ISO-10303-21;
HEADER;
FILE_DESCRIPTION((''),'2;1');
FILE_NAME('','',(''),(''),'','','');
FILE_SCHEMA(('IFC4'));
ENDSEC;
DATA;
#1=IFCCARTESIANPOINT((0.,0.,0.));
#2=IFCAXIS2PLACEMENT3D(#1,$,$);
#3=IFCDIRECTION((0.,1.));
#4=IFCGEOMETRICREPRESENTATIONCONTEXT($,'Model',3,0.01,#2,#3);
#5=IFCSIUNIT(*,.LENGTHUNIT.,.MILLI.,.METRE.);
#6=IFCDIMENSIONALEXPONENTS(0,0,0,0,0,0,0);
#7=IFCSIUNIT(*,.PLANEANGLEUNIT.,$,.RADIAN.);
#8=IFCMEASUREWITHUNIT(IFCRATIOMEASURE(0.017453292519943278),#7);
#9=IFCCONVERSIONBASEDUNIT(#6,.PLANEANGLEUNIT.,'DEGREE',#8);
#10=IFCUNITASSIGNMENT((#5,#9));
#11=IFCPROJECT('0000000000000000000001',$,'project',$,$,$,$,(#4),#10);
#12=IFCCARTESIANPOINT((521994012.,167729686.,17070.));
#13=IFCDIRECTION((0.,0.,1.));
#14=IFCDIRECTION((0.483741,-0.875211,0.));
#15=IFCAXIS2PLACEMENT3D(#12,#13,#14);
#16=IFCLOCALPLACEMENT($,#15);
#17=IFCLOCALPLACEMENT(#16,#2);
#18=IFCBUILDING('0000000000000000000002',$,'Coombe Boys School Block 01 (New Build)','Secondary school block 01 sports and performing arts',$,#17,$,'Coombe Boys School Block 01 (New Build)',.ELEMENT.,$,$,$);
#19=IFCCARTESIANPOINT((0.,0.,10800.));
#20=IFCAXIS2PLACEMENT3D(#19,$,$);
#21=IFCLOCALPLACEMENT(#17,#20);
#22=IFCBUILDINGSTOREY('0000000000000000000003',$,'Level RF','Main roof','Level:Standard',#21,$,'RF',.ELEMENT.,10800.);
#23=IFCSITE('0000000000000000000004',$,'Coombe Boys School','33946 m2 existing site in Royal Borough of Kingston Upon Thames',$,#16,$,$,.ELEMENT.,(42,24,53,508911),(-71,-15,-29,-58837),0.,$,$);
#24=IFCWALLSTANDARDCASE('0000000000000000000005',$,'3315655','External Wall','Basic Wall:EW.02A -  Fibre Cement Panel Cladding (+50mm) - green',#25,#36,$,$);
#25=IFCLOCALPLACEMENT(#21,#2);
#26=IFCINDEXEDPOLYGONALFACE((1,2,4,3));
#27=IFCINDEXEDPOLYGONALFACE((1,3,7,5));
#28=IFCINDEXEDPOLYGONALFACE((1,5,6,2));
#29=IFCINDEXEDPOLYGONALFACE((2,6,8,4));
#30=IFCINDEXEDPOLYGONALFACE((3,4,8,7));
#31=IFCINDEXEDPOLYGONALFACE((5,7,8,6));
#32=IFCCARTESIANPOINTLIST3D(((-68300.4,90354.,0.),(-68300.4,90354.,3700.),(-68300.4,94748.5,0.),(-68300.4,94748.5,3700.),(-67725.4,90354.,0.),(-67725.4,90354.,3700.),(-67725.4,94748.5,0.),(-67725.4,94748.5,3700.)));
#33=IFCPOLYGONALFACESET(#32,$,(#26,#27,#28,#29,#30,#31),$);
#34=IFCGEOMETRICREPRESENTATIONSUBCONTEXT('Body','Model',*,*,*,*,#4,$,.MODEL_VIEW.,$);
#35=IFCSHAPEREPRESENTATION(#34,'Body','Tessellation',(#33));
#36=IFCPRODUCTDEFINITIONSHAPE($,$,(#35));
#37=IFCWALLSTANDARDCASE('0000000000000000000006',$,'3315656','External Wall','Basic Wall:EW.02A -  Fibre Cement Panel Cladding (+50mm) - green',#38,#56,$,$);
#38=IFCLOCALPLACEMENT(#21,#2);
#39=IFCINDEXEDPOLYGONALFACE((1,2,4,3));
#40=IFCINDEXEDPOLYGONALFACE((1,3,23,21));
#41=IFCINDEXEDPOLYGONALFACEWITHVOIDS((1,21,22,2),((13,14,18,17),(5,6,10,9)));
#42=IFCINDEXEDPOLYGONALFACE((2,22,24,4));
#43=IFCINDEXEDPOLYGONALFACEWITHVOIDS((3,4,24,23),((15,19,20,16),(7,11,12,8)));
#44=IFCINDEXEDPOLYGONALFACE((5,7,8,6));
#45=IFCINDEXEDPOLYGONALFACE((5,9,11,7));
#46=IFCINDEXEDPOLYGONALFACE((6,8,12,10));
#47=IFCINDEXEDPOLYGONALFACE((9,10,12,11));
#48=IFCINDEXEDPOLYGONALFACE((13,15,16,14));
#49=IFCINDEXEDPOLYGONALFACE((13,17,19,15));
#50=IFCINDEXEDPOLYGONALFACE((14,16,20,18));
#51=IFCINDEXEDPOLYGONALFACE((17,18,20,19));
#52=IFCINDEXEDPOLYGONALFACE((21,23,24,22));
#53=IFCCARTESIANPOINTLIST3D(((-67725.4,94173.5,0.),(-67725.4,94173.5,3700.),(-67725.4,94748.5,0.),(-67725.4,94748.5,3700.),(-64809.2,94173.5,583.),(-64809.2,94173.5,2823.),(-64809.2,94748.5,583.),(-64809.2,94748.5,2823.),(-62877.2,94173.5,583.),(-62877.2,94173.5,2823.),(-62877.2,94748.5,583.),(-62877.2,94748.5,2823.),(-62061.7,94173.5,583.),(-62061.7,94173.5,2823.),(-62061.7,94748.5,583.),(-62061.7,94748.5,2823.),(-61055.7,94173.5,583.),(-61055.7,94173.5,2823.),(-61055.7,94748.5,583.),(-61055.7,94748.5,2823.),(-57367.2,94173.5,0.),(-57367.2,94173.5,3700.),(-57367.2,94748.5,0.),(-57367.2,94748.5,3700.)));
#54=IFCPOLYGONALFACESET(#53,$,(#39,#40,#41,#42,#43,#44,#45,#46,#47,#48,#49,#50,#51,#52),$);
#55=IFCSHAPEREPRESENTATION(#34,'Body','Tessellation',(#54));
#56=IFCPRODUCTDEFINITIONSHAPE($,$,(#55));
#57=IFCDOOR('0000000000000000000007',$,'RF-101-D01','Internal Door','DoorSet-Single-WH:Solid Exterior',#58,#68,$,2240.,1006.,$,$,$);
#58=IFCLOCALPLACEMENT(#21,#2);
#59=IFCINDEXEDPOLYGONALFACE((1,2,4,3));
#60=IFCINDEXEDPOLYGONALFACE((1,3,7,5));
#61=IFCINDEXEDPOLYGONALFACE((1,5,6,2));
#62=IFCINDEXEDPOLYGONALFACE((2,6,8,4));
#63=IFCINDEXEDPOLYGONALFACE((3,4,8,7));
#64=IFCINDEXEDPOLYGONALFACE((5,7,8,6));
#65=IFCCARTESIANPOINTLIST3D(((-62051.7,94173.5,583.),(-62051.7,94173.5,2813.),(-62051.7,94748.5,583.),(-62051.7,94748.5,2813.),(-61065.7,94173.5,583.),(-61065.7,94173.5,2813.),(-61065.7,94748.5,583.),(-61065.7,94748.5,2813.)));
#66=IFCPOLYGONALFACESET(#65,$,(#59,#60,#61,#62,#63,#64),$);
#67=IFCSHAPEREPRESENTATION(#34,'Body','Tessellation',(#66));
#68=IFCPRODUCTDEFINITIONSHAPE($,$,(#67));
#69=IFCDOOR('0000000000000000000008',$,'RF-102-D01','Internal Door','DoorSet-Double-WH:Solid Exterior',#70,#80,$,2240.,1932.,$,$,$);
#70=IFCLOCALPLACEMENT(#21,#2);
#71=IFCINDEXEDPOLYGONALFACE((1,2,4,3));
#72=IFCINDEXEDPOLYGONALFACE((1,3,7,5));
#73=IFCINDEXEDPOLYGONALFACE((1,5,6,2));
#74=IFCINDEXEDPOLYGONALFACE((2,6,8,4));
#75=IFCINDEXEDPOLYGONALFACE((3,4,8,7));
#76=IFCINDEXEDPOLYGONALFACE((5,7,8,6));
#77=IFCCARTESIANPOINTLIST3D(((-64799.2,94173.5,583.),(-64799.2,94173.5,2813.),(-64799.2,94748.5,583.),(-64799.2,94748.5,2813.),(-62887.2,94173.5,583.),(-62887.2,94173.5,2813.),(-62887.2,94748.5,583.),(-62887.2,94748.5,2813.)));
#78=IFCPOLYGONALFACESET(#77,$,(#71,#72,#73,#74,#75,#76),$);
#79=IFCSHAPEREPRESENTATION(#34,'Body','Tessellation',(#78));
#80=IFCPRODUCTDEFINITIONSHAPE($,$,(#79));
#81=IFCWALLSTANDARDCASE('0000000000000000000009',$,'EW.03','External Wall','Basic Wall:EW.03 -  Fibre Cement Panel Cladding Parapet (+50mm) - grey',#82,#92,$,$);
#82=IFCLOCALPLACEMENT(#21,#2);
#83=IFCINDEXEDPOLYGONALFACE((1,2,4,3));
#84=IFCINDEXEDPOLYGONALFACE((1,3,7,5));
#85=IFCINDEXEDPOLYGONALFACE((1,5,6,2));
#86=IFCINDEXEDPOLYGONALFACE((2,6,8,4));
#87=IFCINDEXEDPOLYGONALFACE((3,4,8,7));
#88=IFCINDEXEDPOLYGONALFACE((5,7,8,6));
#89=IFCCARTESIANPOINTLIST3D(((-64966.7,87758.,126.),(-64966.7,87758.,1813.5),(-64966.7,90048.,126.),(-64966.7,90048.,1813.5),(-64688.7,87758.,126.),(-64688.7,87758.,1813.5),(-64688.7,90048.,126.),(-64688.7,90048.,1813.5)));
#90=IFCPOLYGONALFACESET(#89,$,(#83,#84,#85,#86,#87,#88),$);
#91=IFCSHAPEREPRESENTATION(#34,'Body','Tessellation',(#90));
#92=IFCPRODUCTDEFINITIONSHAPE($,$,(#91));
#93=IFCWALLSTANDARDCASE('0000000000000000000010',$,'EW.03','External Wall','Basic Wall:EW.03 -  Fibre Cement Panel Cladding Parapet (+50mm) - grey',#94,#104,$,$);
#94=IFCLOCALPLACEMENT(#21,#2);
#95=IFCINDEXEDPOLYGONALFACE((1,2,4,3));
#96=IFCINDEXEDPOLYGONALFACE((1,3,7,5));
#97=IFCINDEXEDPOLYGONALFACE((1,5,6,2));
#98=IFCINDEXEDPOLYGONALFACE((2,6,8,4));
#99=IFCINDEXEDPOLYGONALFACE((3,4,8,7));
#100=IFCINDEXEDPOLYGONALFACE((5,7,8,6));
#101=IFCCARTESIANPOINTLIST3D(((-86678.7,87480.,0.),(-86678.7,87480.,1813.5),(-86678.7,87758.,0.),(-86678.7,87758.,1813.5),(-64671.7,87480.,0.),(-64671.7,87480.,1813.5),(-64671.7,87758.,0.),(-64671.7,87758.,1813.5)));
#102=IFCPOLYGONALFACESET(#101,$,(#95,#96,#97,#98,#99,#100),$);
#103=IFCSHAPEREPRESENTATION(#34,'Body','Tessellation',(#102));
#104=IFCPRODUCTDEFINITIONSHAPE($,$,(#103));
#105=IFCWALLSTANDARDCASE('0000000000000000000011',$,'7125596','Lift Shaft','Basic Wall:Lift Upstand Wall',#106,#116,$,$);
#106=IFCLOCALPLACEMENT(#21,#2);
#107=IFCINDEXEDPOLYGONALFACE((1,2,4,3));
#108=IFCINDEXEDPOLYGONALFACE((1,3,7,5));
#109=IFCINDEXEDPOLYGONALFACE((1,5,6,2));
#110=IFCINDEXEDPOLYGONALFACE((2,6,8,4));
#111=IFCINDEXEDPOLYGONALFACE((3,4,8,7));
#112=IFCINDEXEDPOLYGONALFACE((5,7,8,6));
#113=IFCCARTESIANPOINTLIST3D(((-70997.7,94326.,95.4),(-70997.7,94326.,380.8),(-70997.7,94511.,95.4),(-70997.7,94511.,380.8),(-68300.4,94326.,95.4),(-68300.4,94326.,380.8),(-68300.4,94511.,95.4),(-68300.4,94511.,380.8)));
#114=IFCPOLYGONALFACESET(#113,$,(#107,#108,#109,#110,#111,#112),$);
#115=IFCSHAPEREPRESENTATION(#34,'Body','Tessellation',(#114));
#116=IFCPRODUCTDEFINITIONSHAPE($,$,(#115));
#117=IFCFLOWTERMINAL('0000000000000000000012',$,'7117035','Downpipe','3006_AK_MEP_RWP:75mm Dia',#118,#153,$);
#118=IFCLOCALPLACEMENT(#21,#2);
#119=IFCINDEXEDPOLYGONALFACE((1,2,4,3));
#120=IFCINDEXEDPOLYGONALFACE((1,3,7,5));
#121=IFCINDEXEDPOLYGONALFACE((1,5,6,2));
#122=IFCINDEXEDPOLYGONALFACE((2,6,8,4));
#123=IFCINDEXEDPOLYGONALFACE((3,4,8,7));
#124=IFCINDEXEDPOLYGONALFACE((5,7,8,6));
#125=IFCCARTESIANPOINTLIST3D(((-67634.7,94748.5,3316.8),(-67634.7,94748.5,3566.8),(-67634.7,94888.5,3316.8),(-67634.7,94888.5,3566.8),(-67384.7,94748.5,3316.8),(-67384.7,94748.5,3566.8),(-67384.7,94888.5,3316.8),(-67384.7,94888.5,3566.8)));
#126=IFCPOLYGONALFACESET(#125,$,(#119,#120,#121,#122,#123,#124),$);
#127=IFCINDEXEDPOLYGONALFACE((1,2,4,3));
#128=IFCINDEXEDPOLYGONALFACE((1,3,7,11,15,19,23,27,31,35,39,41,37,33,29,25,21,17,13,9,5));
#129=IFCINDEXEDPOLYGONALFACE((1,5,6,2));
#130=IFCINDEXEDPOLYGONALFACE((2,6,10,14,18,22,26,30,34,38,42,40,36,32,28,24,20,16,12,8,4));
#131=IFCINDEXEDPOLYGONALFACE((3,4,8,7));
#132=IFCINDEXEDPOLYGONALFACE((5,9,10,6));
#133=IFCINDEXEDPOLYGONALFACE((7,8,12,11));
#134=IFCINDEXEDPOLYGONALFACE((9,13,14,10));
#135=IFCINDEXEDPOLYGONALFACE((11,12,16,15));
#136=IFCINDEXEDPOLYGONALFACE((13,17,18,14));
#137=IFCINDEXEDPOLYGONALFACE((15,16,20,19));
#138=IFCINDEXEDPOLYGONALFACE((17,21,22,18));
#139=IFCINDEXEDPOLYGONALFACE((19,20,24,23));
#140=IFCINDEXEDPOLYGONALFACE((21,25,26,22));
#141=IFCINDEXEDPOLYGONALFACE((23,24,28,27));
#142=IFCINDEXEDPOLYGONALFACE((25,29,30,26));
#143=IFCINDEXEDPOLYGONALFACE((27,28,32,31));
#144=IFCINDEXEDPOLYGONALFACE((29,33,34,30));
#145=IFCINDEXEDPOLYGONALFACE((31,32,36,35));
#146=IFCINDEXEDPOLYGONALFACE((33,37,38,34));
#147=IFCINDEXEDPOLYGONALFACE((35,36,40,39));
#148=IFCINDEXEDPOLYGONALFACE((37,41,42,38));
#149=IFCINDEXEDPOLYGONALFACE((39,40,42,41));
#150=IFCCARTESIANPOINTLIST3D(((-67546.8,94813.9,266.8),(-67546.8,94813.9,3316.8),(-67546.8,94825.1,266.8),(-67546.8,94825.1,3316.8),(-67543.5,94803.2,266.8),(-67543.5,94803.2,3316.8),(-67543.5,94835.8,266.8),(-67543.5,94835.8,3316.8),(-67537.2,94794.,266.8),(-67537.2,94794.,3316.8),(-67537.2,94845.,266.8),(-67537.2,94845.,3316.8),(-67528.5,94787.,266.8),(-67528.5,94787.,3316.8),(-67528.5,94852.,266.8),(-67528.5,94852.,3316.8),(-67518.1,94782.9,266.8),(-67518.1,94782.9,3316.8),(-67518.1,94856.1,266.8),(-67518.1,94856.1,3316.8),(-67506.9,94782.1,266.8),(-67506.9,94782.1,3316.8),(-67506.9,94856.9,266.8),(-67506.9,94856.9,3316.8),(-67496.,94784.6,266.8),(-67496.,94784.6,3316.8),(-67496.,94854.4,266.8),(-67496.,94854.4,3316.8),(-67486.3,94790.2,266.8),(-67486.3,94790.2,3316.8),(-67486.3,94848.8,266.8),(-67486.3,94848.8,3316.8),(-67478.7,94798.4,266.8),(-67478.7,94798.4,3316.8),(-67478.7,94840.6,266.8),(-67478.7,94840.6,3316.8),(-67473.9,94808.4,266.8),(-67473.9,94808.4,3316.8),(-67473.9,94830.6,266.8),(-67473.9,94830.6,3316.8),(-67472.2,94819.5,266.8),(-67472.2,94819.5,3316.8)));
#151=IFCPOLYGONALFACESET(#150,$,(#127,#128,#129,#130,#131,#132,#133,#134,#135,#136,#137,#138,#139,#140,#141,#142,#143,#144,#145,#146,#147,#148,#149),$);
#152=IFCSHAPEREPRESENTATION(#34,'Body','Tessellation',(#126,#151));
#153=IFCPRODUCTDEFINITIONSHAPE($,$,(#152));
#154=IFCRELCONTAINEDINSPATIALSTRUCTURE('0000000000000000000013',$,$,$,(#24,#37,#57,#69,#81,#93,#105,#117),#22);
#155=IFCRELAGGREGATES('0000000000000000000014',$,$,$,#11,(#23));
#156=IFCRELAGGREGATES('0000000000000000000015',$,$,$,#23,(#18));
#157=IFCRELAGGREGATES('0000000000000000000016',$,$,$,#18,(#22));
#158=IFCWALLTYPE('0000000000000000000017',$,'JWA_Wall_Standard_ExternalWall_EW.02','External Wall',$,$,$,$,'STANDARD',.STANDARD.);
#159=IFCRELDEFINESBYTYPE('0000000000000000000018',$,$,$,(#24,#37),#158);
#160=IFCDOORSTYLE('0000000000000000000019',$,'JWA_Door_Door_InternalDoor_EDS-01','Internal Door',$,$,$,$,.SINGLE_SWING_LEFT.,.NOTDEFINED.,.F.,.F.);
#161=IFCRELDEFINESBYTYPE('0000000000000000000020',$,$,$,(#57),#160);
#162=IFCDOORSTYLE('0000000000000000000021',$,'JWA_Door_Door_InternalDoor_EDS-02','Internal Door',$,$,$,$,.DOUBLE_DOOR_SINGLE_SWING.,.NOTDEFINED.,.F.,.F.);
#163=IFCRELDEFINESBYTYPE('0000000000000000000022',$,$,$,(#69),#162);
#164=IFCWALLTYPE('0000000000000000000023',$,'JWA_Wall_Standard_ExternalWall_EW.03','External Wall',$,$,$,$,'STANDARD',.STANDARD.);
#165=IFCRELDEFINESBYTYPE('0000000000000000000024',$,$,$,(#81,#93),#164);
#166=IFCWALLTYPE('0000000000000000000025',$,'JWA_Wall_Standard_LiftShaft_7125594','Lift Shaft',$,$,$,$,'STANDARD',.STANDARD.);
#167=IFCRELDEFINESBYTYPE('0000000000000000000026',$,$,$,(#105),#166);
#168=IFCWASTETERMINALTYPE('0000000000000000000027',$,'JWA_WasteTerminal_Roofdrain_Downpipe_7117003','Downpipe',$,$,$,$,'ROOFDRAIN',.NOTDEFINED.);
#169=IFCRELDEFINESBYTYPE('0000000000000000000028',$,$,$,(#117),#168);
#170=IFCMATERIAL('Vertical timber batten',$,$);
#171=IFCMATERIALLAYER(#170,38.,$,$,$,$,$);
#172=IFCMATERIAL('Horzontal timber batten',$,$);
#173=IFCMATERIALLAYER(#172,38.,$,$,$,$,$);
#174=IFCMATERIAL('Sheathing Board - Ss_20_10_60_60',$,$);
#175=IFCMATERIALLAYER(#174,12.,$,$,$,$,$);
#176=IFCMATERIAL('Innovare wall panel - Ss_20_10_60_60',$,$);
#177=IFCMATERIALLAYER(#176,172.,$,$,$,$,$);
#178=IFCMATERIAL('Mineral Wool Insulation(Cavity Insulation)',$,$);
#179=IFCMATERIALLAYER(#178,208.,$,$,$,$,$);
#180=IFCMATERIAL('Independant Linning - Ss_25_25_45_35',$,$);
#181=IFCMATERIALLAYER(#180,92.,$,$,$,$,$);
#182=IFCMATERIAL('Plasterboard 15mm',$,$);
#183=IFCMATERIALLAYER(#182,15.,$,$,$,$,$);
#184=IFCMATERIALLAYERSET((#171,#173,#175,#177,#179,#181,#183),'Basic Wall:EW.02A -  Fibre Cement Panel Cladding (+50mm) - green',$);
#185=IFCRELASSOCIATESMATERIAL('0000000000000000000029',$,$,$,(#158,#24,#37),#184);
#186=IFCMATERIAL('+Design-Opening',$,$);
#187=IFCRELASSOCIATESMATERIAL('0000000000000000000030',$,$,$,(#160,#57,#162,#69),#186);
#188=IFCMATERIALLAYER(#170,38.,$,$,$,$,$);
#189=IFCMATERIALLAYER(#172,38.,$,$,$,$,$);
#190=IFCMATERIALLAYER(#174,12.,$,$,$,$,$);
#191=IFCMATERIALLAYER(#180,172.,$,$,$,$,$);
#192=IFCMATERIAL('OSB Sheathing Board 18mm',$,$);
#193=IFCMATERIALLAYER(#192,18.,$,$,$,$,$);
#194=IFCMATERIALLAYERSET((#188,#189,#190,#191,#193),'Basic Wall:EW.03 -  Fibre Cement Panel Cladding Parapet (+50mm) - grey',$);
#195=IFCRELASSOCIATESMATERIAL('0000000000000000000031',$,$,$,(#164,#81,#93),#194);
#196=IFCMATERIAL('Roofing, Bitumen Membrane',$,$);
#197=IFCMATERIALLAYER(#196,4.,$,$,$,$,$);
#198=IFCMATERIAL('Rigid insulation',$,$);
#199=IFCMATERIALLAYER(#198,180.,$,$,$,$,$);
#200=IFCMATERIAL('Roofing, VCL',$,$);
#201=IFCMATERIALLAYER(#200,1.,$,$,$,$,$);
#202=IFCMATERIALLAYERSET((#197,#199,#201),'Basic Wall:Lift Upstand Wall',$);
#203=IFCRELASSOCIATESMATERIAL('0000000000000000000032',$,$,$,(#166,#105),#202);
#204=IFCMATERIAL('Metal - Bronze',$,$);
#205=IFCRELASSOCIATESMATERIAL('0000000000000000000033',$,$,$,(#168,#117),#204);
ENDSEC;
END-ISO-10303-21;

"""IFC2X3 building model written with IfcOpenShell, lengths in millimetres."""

from ifc_helpers import new_model, entity, si_unit, converted_unit, direction, frame, frame_2d, origin, origin_2d_with_axis, place, context, subcontext, project, spatial, rectangle, circle, extrude, source, transform, mapped, material, layer, layer_set, layer_usage, type_object, type_shapes, element, fill, save


model = new_model("IFC2X3")

# Units and contexts
model_context = context("Model", 3, precision=0.01, world=origin(), true_north=direction((0.0, 1.0)))
body_context = subcontext(model_context, "Body", "Model", "MODEL_VIEW")
ifc_project = project(units=[si_unit("LENGTHUNIT", "METRE", prefix="MILLI"), converted_unit("PLANEANGLEUNIT", "DEGREE", entity("IfcRatioMeasure", 0.017453292519943278), si_unit("PLANEANGLEUNIT", "RADIAN"), dimensions=[0, 0, 0, 0, 0, 0, 0])], contexts=[model_context])

# Site, building, storey
site_placement = place(None, frame((521994012.0, 167729686.0, 17070.0), z_axis=(0.0, 0.0, 1.0), x_axis=(0.483741, -0.875211, 0.0)))
site = spatial("IfcSite", under=ifc_project, at=site_placement, Name="Coombe Boys School", Description="33946 m2 existing site in Royal Borough of Kingston Upon Thames", CompositionType="ELEMENT", RefLatitude=(42, 24, 53, 508911), RefLongitude=(-71, -15, -29, -58837), RefElevation=0.0)
building_placement = place(site_placement, origin())
building = spatial("IfcBuilding", under=site, at=building_placement, Name="Coombe Boys School Block 01 (New Build)", Description="Secondary school block 01 sports and performing arts", LongName="Coombe Boys School Block 01 (New Build)", CompositionType="ELEMENT")
storey_placement = place(building_placement, frame((0.0, 0.0, 10800.0)))
storey = spatial("IfcBuildingStorey", under=building, at=storey_placement, Name="Level RF", Description="Main roof", ObjectType="Level:Standard", LongName="RF", CompositionType="ELEMENT", Elevation=10800.0)

# Wall
ifc_material_1 = material(Name="Vertical timber batten")
ifc_layer_1 = layer(ifc_material_1, 38.0)
ifc_material_2 = material(Name="Horzontal timber batten")
ifc_layer_2 = layer(ifc_material_2, 38.0)
ifc_material_3 = material(Name="Sheathing Board - Ss_20_10_60_60")
ifc_layer_3 = layer(ifc_material_3, 12.0)
ifc_material_4 = material(Name="Innovare wall panel - Ss_20_10_60_60")
ifc_layer_4 = layer(ifc_material_4, 172.0)
ifc_material_5 = material(Name="Mineral Wool Insulation(Cavity Insulation)")
ifc_layer_5 = layer(ifc_material_5, 208.0)
ifc_material_6 = material(Name="Independant Linning - Ss_25_25_45_35")
ifc_layer_6 = layer(ifc_material_6, 92.0)
ifc_material_7 = material(Name="Plasterboard 15mm")
ifc_layer_7 = layer(ifc_material_7, 15.0)
ifc_layer_set_1 = layer_set([ifc_layer_1, ifc_layer_2, ifc_layer_3, ifc_layer_4, ifc_layer_5, ifc_layer_6, ifc_layer_7], Name="Basic Wall:EW.02A -  Fibre Cement Panel Cladding (+50mm) - green")
ifc_layer_usage_1 = layer_usage(ifc_layer_set_1, "AXIS2", "NEGATIVE", 287.5)
wall_type_1 = type_object("IfcWallType", Name="JWA_Wall_Standard_ExternalWall_EW.02", Description="External Wall", ElementType="STANDARD", PredefinedType="STANDARD", material=ifc_layer_set_1)
wall_1_placement = place(storey_placement, frame((-68012.9, 90354.0, 0.0), z_axis=(0.0, 0.0, 1.0), x_axis=(0.0, 1.0, 0.0)))
element("IfcWallStandardCase", 1, at=wall_1_placement, inside=storey, type_object=wall_type_1, material=ifc_layer_usage_1, Name="3315655", Description="External Wall", ObjectType="Basic Wall:EW.02A -  Fibre Cement Panel Cladding (+50mm) - green", context=body_context, shape_type="SweptSolid", body=[
    extrude(rectangle(XDim=4394.5, YDim=575.0, at=frame_2d((2197.3, 0.0), x_axis=(-1.0, 0.0))), origin(), (0.0, 0.0, 1.0), 3700.0),
])

# Wall, openings, doors
wall_2_placement = place(storey_placement, frame((-67725.4, 94461.0, 0.0)))
wall_2 = element("IfcWallStandardCase", 2, at=wall_2_placement, inside=storey, type_object=wall_type_1, material=ifc_layer_usage_1, Name="3315656", Description="External Wall", ObjectType="Basic Wall:EW.02A -  Fibre Cement Panel Cladding (+50mm) - green", context=body_context, shape_type="SweptSolid", body=[
    extrude(rectangle(XDim=10358.2, YDim=575.0, at=frame_2d((5179.1, 0.0), x_axis=(-1.0, 0.0))), origin(), (0.0, 0.0, 1.0), 3700.0),
])
opening_1_placement = place(wall_2_placement, frame((67725.4, -94461.0, 0.0)))
opening_1 = element("IfcOpeningElement", 3, at=opening_1_placement, cuts=wall_2, ObjectType="Opening", context=body_context, shape_type="SweptSolid", body=[
    extrude(rectangle(XDim=2240.0, YDim=1932.0, at=origin_2d_with_axis()), frame((-63843.2, 94173.5, 1703.0), z_axis=(0.0, 1.0, 0.0), x_axis=(0.0, 0.0, -1.0)), (0.0, 0.0, 1.0), 575.0),
])
opening_2_placement = place(wall_2_placement, frame((67725.4, -94461.0, 0.0)))
opening_2 = element("IfcOpeningElement", 4, at=opening_2_placement, cuts=wall_2, ObjectType="Opening", context=body_context, shape_type="SweptSolid", body=[
    extrude(rectangle(XDim=2240.0, YDim=1006.0, at=frame_2d((0.0, 0.0), x_axis=(0.0, 1.0))), frame((-61558.7, 94173.5, 1703.0), z_axis=(0.0, 1.0, 0.0), x_axis=(1.0, 0.0, 0.0)), (0.0, 0.0, 1.0), 575.0),
])
ifc_material_8 = material(Name="+Design-Opening")
door_style_1 = type_object("IfcDoorStyle", Name="JWA_Door_Door_InternalDoor_EDS-01", Description="Internal Door", ConstructionType="NOTDEFINED", OperationType="SINGLE_SWING_LEFT", ParameterTakesPrecedence=False, Sizeable=False, material=ifc_material_8)
shared_shape_1 = source(origin(), body_context, "Body", "SweptSolid", [
    extrude(rectangle(XDim=986.0, YDim=575.0, at=origin_2d_with_axis()), frame((125.0, 0.0, 0.0), z_axis=(0.0, 0.0, 1.0), x_axis=(-1.0, 0.0, 0.0)), (0.0, 0.0, 1.0), 2230.0),
])
type_shapes(door_style_1, [shared_shape_1])
door_1_placement = place(opening_2_placement, frame((-61433.7, 94461.0, 583.0), z_axis=(0.0, 0.0, 1.0), x_axis=(-1.0, 0.0, 0.0)))
door_1 = element("IfcDoor", 5, at=door_1_placement, inside=storey, type_object=door_style_1, material=ifc_material_8, Name="RF-101-D01", Description="Internal Door", ObjectType="DoorSet-Single-WH:Solid Exterior", OverallHeight=2240.0, OverallWidth=1006.0, context=body_context, shape_type="MappedRepresentation", body=[
    mapped(shared_shape_1, transform((0.0, 0.0, 0.0), scale=1.0)),
])
fill(opening_2, door_1)
door_style_2 = type_object("IfcDoorStyle", Name="JWA_Door_Door_InternalDoor_EDS-02", Description="Internal Door", ConstructionType="NOTDEFINED", OperationType="DOUBLE_DOOR_SINGLE_SWING", ParameterTakesPrecedence=False, Sizeable=False, material=ifc_material_8)
shared_shape_2 = source(origin(), body_context, "Body", "SweptSolid", [
    extrude(rectangle(XDim=575.0, YDim=1912.0, at=frame_2d((0.0, 0.0), x_axis=(1.0, 0.0))), frame((125.0, 0.0, 0.0), z_axis=(0.0, 0.0, 1.0), x_axis=(0.0, 1.0, 0.0)), (0.0, 0.0, 1.0), 2230.0),
])
type_shapes(door_style_2, [shared_shape_2])
door_2_placement = place(opening_1_placement, frame((-63968.2, 94461.0, 583.0)))
door_2 = element("IfcDoor", 6, at=door_2_placement, inside=storey, type_object=door_style_2, material=ifc_material_8, Name="RF-102-D01", Description="Internal Door", ObjectType="DoorSet-Double-WH:Solid Exterior", OverallHeight=2240.0, OverallWidth=1932.0, context=body_context, shape_type="MappedRepresentation", body=[
    mapped(shared_shape_2, transform((0.0, 0.0, 0.0), scale=1.0)),
])
fill(opening_1, door_2)

# Walls
ifc_layer_8 = layer(ifc_material_1, 38.0)
ifc_layer_9 = layer(ifc_material_2, 38.0)
ifc_layer_10 = layer(ifc_material_3, 12.0)
ifc_layer_11 = layer(ifc_material_6, 172.0)
ifc_material_9 = material(Name="OSB Sheathing Board 18mm")
ifc_layer_12 = layer(ifc_material_9, 18.0)
ifc_layer_set_2 = layer_set([ifc_layer_8, ifc_layer_9, ifc_layer_10, ifc_layer_11, ifc_layer_12], Name="Basic Wall:EW.03 -  Fibre Cement Panel Cladding Parapet (+50mm) - grey")
ifc_layer_usage_2 = layer_usage(ifc_layer_set_2, "AXIS2", "NEGATIVE", 139.0)
wall_type_2 = type_object("IfcWallType", Name="JWA_Wall_Standard_ExternalWall_EW.03", Description="External Wall", ElementType="STANDARD", PredefinedType="STANDARD", material=ifc_layer_set_2)
wall_3_placement = place(storey_placement, frame((-64827.7, 90048.0, 126.0), z_axis=(0.0, 0.0, 1.0), x_axis=(0.0, -1.0, 0.0)))
element("IfcWallStandardCase", 7, at=wall_3_placement, inside=storey, type_object=wall_type_2, material=ifc_layer_usage_2, Name="EW.03", Description="External Wall", ObjectType="Basic Wall:EW.03 -  Fibre Cement Panel Cladding Parapet (+50mm) - grey", context=body_context, shape_type="SweptSolid", body=[
    extrude(rectangle(XDim=2290.0, YDim=278.0, at=frame_2d((1145.0, 0.0), x_axis=(-1.0, 0.0))), origin(), (0.0, 0.0, 1.0), 1687.4),
])
wall_4_placement = place(storey_placement, frame((-64671.7, 87619.0, 0.0), z_axis=(0.0, 0.0, 1.0), x_axis=(-1.0, 0.0, 0.0)))
element("IfcWallStandardCase", 8, at=wall_4_placement, inside=storey, type_object=wall_type_2, material=ifc_layer_usage_2, Name="EW.03", Description="External Wall", ObjectType="Basic Wall:EW.03 -  Fibre Cement Panel Cladding Parapet (+50mm) - grey", context=body_context, shape_type="SweptSolid", body=[
    extrude(rectangle(XDim=22007.0, YDim=278.0, at=frame_2d((11003.5, 0.0), x_axis=(-1.0, 0.0))), origin(), (0.0, 0.0, 1.0), 1813.5),
])
ifc_material_10 = material(Name="Roofing, Bitumen Membrane")
ifc_layer_13 = layer(ifc_material_10, 4.0)
ifc_material_11 = material(Name="Rigid insulation")
ifc_layer_14 = layer(ifc_material_11, 180.0)
ifc_material_12 = material(Name="Roofing, VCL")
ifc_layer_15 = layer(ifc_material_12, 1.0)
ifc_layer_set_3 = layer_set([ifc_layer_13, ifc_layer_14, ifc_layer_15], Name="Basic Wall:Lift Upstand Wall")
ifc_layer_usage_3 = layer_usage(ifc_layer_set_3, "AXIS2", "POSITIVE", -92.5)
wall_type_3 = type_object("IfcWallType", Name="JWA_Wall_Standard_LiftShaft_7125594", Description="Lift Shaft", ElementType="STANDARD", PredefinedType="STANDARD", material=ifc_layer_set_3)
wall_5_placement = place(storey_placement, frame((-68300.4, 94418.5, 95.4), z_axis=(0.0, 0.0, 1.0), x_axis=(-1.0, 0.0, 0.0)))
element("IfcWallStandardCase", 9, at=wall_5_placement, inside=storey, type_object=wall_type_3, material=ifc_layer_usage_3, Name="7125596", Description="Lift Shaft", ObjectType="Basic Wall:Lift Upstand Wall", context=body_context, shape_type="SweptSolid", body=[
    extrude(rectangle(XDim=2697.3, YDim=185.0, at=frame_2d((1348.7, 0.0), x_axis=(-1.0, 0.0))), origin(), (0.0, 0.0, 1.0), 285.3),
])

# Flow terminal
ifc_material_13 = material(Name="Metal - Bronze")
waste_terminal_type = type_object("IfcWasteTerminalType", Name="JWA_WasteTerminal_Roofdrain_Downpipe_7117003", Description="Downpipe", ElementType="ROOFDRAIN", PredefinedType="NOTDEFINED", material=ifc_material_13)
shared_shape_3 = source(origin(), body_context, "Body", "SweptSolid", [
    extrude(rectangle(XDim=140.0, YDim=250.0, at=origin_2d_with_axis()), frame((125.0, 357.5, 3050.0), z_axis=(0.0, 0.0, 1.0), x_axis=(0.0, -1.0, 0.0)), (0.0, 0.0, 1.0), 250.0),
    extrude(circle(Radius=37.5, at=frame_2d((0.0, 0.0), x_axis=(1.0, 0.0))), frame((125.0, 358.5, 0.0)), (0.0, 0.0, 1.0), 3050.0),
])
type_shapes(waste_terminal_type, [shared_shape_3])
flow_terminal_placement = place(storey_placement, frame((-67634.7, 94461.0, 266.8)))
element("IfcFlowTerminal", 10, at=flow_terminal_placement, inside=storey, type_object=waste_terminal_type, material=ifc_material_13, Name="7117035", Description="Downpipe", ObjectType="3006_AK_MEP_RWP:75mm Dia", context=body_context, shape_type="MappedRepresentation", body=[
    mapped(shared_shape_3, transform((0.0, 0.0, 0.0), scale=1.0)),
])

save(model, "model.ifc")
